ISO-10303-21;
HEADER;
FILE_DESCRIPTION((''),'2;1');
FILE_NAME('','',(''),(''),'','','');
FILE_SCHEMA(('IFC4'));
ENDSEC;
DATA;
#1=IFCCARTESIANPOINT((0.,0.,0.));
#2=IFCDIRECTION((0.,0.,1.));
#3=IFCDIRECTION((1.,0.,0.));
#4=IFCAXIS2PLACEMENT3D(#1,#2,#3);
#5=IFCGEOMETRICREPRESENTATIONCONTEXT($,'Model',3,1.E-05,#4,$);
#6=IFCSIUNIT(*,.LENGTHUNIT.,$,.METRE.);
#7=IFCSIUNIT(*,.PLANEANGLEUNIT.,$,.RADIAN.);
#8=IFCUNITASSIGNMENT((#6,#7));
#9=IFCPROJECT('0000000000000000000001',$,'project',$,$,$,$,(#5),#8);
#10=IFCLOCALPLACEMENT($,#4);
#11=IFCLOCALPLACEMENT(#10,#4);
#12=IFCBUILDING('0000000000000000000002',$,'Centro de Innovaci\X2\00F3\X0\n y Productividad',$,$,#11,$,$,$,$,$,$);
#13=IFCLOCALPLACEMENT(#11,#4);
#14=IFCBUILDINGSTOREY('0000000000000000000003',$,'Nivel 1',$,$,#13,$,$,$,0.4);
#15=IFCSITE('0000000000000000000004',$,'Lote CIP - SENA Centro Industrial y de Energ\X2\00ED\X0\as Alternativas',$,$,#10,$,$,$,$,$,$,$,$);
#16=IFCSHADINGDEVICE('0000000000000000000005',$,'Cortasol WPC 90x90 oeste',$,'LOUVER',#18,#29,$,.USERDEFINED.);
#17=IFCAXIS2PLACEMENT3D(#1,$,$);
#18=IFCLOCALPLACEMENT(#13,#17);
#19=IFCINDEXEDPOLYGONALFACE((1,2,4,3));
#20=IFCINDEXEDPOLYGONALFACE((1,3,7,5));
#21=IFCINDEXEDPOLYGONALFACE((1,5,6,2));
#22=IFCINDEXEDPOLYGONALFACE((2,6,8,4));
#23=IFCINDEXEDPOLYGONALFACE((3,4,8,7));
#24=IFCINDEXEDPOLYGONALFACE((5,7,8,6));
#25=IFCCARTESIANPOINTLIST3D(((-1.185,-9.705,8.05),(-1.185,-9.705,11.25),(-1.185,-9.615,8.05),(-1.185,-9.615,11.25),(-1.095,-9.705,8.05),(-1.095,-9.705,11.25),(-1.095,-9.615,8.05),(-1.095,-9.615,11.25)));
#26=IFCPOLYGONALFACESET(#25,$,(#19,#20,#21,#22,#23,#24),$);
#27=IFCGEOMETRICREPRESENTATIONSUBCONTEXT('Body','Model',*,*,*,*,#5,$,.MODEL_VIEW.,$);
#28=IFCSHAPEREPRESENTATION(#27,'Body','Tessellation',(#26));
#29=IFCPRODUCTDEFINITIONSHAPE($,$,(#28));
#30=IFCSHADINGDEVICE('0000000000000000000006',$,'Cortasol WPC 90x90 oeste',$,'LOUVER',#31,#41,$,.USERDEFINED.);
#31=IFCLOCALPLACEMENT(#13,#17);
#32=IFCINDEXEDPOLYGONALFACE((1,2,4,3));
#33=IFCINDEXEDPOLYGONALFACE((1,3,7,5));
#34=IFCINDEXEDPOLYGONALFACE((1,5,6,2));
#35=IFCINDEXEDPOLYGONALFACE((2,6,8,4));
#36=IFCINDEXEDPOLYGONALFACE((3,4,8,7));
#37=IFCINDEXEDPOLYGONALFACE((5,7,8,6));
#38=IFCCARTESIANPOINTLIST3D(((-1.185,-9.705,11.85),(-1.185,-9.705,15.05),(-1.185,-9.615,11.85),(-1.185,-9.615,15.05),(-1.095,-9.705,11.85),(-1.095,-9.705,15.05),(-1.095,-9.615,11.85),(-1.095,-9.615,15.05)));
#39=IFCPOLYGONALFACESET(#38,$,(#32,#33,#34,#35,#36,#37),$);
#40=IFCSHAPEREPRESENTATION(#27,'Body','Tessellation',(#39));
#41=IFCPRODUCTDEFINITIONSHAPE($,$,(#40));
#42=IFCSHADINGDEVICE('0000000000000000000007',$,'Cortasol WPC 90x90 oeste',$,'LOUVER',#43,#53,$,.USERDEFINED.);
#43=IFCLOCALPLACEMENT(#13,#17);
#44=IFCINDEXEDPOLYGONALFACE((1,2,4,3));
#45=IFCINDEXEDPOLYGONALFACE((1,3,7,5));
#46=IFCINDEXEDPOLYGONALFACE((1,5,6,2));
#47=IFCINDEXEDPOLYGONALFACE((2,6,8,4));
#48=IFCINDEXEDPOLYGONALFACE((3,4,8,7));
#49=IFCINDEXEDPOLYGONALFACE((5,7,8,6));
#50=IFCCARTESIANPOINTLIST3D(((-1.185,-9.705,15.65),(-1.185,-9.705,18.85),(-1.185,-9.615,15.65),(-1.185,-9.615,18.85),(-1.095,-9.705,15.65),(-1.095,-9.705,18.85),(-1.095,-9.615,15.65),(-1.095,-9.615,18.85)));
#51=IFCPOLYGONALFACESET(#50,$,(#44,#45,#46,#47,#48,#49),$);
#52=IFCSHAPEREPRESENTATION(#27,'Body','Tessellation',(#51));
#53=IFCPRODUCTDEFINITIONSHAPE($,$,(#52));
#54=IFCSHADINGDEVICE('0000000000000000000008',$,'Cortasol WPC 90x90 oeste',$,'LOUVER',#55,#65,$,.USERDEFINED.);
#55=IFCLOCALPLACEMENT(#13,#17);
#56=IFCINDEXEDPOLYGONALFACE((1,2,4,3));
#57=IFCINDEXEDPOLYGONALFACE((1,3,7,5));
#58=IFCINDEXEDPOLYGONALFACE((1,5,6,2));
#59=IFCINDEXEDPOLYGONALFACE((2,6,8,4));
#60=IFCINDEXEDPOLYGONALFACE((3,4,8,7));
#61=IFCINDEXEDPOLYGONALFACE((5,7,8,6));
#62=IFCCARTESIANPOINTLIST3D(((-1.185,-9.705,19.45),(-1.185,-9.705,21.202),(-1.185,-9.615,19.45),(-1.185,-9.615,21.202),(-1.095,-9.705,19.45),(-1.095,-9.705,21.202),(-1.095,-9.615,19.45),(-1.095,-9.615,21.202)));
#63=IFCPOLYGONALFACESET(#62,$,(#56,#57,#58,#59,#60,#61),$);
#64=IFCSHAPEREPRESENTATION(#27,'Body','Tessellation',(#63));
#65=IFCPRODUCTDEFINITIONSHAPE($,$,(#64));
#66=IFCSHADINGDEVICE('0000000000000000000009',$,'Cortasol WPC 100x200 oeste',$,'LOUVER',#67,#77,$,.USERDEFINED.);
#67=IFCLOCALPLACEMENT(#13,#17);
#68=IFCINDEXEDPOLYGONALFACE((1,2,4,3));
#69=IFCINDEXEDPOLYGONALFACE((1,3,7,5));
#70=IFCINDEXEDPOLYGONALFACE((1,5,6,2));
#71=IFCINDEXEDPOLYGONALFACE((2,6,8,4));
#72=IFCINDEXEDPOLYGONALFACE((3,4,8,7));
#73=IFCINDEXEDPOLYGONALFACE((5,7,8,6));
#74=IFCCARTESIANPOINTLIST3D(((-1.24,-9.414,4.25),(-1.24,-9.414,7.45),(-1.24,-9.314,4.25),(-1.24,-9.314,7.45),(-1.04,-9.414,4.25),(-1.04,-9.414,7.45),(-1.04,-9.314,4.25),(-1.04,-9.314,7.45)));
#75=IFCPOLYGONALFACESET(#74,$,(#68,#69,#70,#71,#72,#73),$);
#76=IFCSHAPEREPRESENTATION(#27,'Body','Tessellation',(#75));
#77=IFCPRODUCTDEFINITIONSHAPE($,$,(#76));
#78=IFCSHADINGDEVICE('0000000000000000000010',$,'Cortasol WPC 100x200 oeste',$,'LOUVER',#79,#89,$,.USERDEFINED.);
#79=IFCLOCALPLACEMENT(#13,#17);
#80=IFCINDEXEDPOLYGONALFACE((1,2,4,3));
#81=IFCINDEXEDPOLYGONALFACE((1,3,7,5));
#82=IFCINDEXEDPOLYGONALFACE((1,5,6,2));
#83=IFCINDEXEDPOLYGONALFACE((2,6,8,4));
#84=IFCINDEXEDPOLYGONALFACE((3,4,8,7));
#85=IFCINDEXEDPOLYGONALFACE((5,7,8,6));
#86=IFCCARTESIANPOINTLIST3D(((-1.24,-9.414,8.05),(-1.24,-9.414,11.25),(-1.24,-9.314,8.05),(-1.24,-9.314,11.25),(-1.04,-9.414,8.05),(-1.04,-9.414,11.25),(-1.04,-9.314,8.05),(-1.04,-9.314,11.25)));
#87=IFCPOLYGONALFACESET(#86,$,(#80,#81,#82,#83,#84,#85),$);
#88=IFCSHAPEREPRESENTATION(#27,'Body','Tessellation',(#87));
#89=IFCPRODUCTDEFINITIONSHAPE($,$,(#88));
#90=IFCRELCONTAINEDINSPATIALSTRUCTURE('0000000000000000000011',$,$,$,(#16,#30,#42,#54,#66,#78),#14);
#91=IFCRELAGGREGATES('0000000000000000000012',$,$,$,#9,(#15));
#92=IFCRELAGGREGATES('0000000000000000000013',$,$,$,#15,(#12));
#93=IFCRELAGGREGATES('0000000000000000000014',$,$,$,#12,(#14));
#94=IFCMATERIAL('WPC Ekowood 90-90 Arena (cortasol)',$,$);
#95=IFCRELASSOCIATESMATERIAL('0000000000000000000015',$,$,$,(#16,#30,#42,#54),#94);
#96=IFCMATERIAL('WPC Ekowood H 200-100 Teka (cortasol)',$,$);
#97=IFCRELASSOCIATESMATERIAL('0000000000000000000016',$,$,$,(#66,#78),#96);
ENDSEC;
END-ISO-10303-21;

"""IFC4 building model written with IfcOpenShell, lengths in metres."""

from ifc_helpers import new_model, si_unit, frame, origin_with_axes, place, context, subcontext, project, spatial, polyline, outline, extrude, material, element, save


model = new_model("IFC4")

# Units and contexts
model_context = context("Model", 3, precision=1e-05, world=origin_with_axes())
body_context = subcontext(model_context, "Body", "Model", "MODEL_VIEW")
ifc_project = project(units=[si_unit("LENGTHUNIT", "METRE"), si_unit("PLANEANGLEUNIT", "RADIAN")], contexts=[model_context])

# Site, building, storey
site_placement = place(None, origin_with_axes())
site = spatial("IfcSite", under=ifc_project, at=site_placement, Name="Lote CIP - SENA Centro Industrial y de Energías Alternativas")
building_placement = place(site_placement, origin_with_axes())
building = spatial("IfcBuilding", under=site, at=building_placement, Name="Centro de Innovación y Productividad")
storey_placement = place(building_placement, origin_with_axes())
storey = spatial("IfcBuildingStorey", under=building, at=storey_placement, Name="Nivel 1", Elevation=0.4)

# Shading devices
ifc_material_1 = material(Name="WPC Ekowood H 200-100 Teka (cortasol)")
ifc_material_2 = material(Name="WPC Ekowood 90-90 Arena (cortasol)")
shading_device_1_placement = place(storey_placement, origin_with_axes())
element("IfcShadingDevice", 1, at=shading_device_1_placement, inside=storey, material=ifc_material_2, Name="Cortasol WPC 90x90 oeste", ObjectType="LOUVER", PredefinedType="USERDEFINED", context=body_context, shape_type="SweptSolid", body=[
    extrude(outline(polyline([(-1.095, -9.705), (-1.185, -9.705), (-1.185, -9.615), (-1.095, -9.615), (-1.095, -9.705)])), frame((0.0, 0.0, 8.05)), (0.0, 0.0, 1.0), 3.2),
])
shading_device_2_placement = place(storey_placement, origin_with_axes())
element("IfcShadingDevice", 2, at=shading_device_2_placement, inside=storey, material=ifc_material_2, Name="Cortasol WPC 90x90 oeste", ObjectType="LOUVER", PredefinedType="USERDEFINED", context=body_context, shape_type="SweptSolid", body=[
    extrude(outline(polyline([(-1.095, -9.705), (-1.185, -9.705), (-1.185, -9.615), (-1.095, -9.615), (-1.095, -9.705)])), frame((0.0, 0.0, 11.85)), (0.0, 0.0, 1.0), 3.2),
])
shading_device_3_placement = place(storey_placement, origin_with_axes())
element("IfcShadingDevice", 3, at=shading_device_3_placement, inside=storey, material=ifc_material_2, Name="Cortasol WPC 90x90 oeste", ObjectType="LOUVER", PredefinedType="USERDEFINED", context=body_context, shape_type="SweptSolid", body=[
    extrude(outline(polyline([(-1.095, -9.705), (-1.185, -9.705), (-1.185, -9.615), (-1.095, -9.615), (-1.095, -9.705)])), frame((0.0, 0.0, 15.65)), (0.0, 0.0, 1.0), 3.2),
])
shading_device_4_placement = place(storey_placement, origin_with_axes())
element("IfcShadingDevice", 4, at=shading_device_4_placement, inside=storey, material=ifc_material_2, Name="Cortasol WPC 90x90 oeste", ObjectType="LOUVER", PredefinedType="USERDEFINED", context=body_context, shape_type="SweptSolid", body=[
    extrude(outline(polyline([(-1.095, -9.705), (-1.185, -9.705), (-1.185, -9.615), (-1.095, -9.615), (-1.095, -9.705)])), frame((0.0, 0.0, 19.45)), (0.0, 0.0, 1.0), 1.752),
])
shading_device_5_placement = place(storey_placement, origin_with_axes())
element("IfcShadingDevice", 5, at=shading_device_5_placement, inside=storey, material=ifc_material_1, Name="Cortasol WPC 100x200 oeste", ObjectType="LOUVER", PredefinedType="USERDEFINED", context=body_context, shape_type="SweptSolid", body=[
    extrude(outline(polyline([(-1.04, -9.414), (-1.24, -9.414), (-1.24, -9.314), (-1.04, -9.314), (-1.04, -9.414)])), frame((0.0, 0.0, 4.25)), (0.0, 0.0, 1.0), 3.2),
])
shading_device_6_placement = place(storey_placement, origin_with_axes())
element("IfcShadingDevice", 6, at=shading_device_6_placement, inside=storey, material=ifc_material_1, Name="Cortasol WPC 100x200 oeste", ObjectType="LOUVER", PredefinedType="USERDEFINED", context=body_context, shape_type="SweptSolid", body=[
    extrude(outline(polyline([(-1.04, -9.414), (-1.24, -9.414), (-1.24, -9.314), (-1.04, -9.314), (-1.04, -9.414)])), frame((0.0, 0.0, 8.05)), (0.0, 0.0, 1.0), 3.2),
])

save(model, "model.ifc")
